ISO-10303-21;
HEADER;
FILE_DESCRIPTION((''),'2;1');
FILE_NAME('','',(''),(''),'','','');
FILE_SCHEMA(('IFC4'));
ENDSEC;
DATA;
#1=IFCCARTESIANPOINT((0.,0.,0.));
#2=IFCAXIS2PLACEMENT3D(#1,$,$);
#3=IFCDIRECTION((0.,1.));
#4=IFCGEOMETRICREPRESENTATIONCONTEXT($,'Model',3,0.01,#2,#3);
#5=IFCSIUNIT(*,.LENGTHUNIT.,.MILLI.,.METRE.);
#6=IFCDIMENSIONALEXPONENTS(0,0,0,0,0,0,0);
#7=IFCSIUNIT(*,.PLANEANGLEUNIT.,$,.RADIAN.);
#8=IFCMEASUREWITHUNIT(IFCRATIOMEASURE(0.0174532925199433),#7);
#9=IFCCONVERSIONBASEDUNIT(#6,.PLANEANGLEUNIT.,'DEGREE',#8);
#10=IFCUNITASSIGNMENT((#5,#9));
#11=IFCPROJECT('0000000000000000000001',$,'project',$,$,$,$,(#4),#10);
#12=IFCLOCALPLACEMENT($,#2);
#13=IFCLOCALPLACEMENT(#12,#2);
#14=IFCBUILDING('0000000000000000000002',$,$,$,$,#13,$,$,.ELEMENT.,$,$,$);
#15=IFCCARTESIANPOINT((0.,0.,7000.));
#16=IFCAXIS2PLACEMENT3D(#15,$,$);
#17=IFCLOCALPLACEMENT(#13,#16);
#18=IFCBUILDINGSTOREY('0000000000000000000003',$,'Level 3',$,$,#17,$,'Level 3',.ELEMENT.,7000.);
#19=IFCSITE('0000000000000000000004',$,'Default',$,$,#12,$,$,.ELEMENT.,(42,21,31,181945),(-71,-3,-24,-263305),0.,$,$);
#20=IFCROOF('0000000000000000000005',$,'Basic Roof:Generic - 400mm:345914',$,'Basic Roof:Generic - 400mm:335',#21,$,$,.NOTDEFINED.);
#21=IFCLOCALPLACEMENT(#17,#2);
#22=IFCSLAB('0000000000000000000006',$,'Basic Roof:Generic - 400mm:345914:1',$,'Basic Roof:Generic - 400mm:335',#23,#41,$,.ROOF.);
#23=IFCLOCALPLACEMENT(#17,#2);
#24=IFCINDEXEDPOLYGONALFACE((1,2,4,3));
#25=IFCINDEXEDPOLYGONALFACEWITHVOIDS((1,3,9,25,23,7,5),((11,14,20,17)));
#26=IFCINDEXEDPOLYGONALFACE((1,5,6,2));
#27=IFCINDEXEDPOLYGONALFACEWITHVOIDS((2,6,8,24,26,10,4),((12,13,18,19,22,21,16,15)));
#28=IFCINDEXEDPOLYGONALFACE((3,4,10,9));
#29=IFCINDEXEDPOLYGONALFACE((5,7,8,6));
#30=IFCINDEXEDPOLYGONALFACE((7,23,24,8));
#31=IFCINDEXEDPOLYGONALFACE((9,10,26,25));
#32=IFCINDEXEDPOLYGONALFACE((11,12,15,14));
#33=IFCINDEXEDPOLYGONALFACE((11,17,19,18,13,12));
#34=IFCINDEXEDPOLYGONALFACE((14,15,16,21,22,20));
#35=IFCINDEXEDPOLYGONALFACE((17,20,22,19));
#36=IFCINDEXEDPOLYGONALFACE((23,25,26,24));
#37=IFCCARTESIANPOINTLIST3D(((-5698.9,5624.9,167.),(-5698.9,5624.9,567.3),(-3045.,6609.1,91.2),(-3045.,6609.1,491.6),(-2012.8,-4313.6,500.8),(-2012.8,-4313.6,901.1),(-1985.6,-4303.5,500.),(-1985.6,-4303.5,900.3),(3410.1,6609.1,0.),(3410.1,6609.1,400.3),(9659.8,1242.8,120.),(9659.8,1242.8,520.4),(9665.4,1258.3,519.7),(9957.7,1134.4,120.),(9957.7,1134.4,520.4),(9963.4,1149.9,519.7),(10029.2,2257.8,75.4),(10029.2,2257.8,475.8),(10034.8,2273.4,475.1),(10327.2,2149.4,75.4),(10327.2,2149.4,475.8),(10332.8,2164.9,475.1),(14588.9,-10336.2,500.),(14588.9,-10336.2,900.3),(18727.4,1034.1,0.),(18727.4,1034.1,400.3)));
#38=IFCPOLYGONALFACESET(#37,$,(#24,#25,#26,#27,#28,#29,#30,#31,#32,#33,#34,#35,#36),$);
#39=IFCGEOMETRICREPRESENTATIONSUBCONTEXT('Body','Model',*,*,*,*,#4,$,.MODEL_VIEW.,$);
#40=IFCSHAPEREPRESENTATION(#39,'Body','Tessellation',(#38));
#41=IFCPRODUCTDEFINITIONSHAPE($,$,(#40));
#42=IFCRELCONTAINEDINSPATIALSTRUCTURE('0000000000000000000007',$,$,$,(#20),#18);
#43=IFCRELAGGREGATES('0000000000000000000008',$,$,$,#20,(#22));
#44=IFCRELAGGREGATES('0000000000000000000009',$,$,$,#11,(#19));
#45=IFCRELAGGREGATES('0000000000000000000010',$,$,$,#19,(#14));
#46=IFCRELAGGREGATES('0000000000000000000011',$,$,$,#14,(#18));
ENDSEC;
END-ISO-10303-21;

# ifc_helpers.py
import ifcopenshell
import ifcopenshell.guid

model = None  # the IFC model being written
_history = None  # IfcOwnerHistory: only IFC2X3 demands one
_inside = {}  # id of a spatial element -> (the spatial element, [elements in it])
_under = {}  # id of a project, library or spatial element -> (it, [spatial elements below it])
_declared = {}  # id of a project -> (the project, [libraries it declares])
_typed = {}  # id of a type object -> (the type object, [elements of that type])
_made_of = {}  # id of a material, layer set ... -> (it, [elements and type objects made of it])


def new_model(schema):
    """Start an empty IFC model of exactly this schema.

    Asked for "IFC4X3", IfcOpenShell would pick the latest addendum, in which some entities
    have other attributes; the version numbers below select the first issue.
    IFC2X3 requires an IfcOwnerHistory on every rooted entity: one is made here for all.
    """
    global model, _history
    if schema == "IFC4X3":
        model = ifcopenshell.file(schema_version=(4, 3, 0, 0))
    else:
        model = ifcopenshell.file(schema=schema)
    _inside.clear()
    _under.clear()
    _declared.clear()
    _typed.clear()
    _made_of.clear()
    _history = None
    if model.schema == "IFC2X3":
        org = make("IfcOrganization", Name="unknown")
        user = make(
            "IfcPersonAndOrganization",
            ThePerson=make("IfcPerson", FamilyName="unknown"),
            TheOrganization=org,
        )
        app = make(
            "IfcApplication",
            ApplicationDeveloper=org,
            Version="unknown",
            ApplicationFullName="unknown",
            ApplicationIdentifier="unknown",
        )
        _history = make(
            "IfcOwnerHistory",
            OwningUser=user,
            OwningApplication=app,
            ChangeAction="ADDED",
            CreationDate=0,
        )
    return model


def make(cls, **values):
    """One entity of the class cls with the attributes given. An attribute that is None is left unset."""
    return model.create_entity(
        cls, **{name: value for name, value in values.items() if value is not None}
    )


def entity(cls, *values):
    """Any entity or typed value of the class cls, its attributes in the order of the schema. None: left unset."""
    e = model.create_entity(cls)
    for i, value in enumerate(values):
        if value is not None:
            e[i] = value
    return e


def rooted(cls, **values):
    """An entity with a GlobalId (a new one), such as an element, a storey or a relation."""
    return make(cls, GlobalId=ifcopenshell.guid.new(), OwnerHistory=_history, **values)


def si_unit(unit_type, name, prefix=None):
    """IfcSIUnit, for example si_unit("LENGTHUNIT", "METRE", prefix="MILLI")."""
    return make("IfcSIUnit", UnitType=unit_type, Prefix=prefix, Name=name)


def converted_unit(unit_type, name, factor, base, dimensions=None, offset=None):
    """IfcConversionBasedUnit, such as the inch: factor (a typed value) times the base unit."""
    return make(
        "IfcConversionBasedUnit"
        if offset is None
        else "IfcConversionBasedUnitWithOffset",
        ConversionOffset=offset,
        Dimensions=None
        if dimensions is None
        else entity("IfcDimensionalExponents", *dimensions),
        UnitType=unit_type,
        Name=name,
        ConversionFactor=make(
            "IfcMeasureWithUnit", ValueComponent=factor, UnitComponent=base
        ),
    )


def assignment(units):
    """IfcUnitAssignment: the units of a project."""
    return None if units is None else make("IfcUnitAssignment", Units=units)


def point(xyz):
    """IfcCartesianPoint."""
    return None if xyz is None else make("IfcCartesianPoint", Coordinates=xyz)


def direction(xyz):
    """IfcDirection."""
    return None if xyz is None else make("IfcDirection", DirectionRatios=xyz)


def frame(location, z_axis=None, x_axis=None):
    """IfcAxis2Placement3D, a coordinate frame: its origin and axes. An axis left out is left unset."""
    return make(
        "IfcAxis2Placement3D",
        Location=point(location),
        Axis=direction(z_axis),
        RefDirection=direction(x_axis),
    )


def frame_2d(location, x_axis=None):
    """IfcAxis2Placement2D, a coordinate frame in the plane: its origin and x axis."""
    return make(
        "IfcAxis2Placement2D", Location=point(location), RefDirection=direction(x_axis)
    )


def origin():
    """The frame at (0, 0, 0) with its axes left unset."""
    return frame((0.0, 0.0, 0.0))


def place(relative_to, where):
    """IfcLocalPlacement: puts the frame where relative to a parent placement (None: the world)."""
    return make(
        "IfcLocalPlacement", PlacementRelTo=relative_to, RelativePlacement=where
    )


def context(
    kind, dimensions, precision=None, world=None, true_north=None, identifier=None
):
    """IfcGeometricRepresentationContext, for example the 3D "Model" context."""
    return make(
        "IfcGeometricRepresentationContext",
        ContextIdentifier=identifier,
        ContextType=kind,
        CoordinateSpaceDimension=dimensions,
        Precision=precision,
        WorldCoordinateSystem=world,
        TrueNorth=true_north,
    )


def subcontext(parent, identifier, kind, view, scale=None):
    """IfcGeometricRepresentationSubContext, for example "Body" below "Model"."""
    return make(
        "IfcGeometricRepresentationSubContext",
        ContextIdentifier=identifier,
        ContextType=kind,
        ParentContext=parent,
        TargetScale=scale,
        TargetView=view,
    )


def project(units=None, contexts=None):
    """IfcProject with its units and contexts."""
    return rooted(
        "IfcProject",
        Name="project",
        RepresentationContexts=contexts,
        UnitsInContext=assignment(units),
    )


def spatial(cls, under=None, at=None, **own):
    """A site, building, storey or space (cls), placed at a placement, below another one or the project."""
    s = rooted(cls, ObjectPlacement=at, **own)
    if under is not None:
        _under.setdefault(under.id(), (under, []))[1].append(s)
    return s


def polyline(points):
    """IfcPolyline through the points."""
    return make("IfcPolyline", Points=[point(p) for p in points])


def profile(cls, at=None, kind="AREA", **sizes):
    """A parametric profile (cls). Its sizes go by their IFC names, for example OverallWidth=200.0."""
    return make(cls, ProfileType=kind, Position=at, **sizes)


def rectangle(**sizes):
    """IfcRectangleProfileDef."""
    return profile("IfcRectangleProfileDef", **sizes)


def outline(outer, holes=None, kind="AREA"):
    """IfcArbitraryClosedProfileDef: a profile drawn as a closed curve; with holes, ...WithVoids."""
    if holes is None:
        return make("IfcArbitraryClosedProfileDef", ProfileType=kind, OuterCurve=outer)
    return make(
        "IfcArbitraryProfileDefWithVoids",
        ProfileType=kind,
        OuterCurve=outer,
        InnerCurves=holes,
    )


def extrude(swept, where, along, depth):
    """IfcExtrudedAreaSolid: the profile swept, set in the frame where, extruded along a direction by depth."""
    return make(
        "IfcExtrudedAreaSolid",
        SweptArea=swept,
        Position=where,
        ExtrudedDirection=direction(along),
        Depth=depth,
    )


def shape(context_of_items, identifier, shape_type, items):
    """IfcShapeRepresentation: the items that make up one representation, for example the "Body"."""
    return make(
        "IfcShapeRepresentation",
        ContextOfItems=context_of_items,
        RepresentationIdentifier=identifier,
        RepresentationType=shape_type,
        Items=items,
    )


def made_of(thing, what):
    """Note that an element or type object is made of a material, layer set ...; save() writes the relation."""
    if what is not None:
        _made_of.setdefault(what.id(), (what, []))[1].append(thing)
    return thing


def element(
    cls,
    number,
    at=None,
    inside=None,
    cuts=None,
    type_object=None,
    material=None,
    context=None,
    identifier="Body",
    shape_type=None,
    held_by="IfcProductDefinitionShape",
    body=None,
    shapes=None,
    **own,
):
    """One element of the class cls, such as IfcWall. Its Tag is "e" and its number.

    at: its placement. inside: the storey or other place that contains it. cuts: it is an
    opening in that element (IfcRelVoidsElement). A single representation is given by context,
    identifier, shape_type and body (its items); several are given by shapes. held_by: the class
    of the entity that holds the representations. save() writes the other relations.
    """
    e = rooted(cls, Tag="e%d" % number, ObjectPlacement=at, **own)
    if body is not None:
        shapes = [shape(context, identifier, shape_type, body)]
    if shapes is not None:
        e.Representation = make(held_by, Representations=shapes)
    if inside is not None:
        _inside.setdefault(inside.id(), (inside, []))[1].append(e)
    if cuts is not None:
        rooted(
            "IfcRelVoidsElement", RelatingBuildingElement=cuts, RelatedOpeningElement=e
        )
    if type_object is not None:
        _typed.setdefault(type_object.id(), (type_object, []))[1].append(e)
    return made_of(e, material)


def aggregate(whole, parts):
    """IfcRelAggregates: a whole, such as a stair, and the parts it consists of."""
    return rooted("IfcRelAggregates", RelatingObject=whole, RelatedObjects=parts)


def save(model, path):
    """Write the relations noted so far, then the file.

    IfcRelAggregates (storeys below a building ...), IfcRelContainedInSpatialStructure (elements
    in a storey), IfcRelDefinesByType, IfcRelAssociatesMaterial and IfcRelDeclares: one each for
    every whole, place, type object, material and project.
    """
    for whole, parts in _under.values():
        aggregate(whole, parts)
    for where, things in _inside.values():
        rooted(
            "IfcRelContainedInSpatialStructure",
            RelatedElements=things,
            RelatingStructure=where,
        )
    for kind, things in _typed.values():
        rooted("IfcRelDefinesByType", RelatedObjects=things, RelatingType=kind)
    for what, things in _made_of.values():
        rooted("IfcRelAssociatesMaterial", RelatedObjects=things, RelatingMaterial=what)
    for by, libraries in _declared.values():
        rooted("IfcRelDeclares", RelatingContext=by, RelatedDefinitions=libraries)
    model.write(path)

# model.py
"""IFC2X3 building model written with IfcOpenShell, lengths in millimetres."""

from ifc_helpers import new_model, entity, si_unit, converted_unit, direction, frame, frame_2d, origin, place, context, subcontext, project, spatial, polyline, rectangle, outline, extrude, element, aggregate, save


model = new_model("IFC2X3")

# Units and contexts
model_context = context("Model", 3, precision=0.01, world=origin(), true_north=direction((0.0, 1.0)))
body_context = subcontext(model_context, "Body", "Model", "MODEL_VIEW")
ifc_project = project(units=[si_unit("LENGTHUNIT", "METRE", prefix="MILLI"), converted_unit("PLANEANGLEUNIT", "DEGREE", entity("IfcRatioMeasure", 0.0174532925199433), si_unit("PLANEANGLEUNIT", "RADIAN"), dimensions=[0, 0, 0, 0, 0, 0, 0])], contexts=[model_context])

# Site, building, storey
site_placement = place(None, origin())
site = spatial("IfcSite", under=ifc_project, at=site_placement, Name="Default", CompositionType="ELEMENT", RefLatitude=(42, 21, 31, 181945), RefLongitude=(-71, -3, -24, -263305), RefElevation=0.0)
building_placement = place(site_placement, origin())
building = spatial("IfcBuilding", under=site, at=building_placement, CompositionType="ELEMENT")
storey_placement = place(building_placement, frame((0.0, 0.0, 7000.0)))
storey = spatial("IfcBuildingStorey", under=building, at=storey_placement, Name="Level 3", LongName="Level 3", CompositionType="ELEMENT", Elevation=7000.0)

# Roof, slab, openings
roof_placement = place(storey_placement, origin())
roof = element("IfcRoof", 1, at=roof_placement, inside=storey, Name="Basic Roof:Generic - 400mm:345914", ObjectType="Basic Roof:Generic - 400mm:335", ShapeType="NOTDEFINED")
slab_placement = place(storey_placement, origin())
slab = element("IfcSlab", 2, at=slab_placement, Name="Basic Roof:Generic - 400mm:345914:1", ObjectType="Basic Roof:Generic - 400mm:335", PredefinedType="ROOF", context=body_context, shape_type="SweptSolid", body=[
    extrude(outline(polyline([(12.7, -6482.0), (6468.4, -6482.0), (9123.1, -5497.0), (5442.1, 4448.9), (5414.9, 4438.9), (-11158.0, 10476.1), (-15303.1, -902.8), (12.7, -6482.0)])), frame((3426.3, 132.0, 251.3), z_axis=(0.014121, 0.038797, 0.999147), x_axis=(-0.9999, 0.0, 0.014132)), (0.014132, 0.038793, 0.999147), 400.3),
])
opening_1_placement = place(storey_placement, origin())
element("IfcOpeningElement", 3, at=opening_1_placement, cuts=slab, ObjectType="Opening", context=body_context, shape_type="SweptSolid", body=[
    extrude(rectangle(XDim=1081.1, YDim=317.1, at=frame_2d((0.0, 0.0), x_axis=(1.0, 0.0))), frame((9999.1, 1711.6, 497.4), z_axis=(-0.014121, -0.038797, -0.999147), x_axis=(-0.341729, -0.938891, 0.041287)), (0.0, 0.0, 1.0), 400.0),
])
opening_2_placement = place(storey_placement, origin())
element("IfcOpeningElement", 4, at=opening_2_placement, cuts=slab, ObjectType="Opening", context=body_context, shape_type="SweptSolid", body=[
    extrude(rectangle(XDim=1081.1, YDim=317.1, at=frame_2d((0.0, 0.0), x_axis=(0.0, 1.0))), frame((9993.5, 1696.1, 97.7), z_axis=(0.014121, 0.038797, 0.999147), x_axis=(-0.939693, 0.34202, 0.0)), (0.0, 0.041287, 0.999147), 400.3),
])
aggregate(roof, [slab])

save(model, "model.ifc")
